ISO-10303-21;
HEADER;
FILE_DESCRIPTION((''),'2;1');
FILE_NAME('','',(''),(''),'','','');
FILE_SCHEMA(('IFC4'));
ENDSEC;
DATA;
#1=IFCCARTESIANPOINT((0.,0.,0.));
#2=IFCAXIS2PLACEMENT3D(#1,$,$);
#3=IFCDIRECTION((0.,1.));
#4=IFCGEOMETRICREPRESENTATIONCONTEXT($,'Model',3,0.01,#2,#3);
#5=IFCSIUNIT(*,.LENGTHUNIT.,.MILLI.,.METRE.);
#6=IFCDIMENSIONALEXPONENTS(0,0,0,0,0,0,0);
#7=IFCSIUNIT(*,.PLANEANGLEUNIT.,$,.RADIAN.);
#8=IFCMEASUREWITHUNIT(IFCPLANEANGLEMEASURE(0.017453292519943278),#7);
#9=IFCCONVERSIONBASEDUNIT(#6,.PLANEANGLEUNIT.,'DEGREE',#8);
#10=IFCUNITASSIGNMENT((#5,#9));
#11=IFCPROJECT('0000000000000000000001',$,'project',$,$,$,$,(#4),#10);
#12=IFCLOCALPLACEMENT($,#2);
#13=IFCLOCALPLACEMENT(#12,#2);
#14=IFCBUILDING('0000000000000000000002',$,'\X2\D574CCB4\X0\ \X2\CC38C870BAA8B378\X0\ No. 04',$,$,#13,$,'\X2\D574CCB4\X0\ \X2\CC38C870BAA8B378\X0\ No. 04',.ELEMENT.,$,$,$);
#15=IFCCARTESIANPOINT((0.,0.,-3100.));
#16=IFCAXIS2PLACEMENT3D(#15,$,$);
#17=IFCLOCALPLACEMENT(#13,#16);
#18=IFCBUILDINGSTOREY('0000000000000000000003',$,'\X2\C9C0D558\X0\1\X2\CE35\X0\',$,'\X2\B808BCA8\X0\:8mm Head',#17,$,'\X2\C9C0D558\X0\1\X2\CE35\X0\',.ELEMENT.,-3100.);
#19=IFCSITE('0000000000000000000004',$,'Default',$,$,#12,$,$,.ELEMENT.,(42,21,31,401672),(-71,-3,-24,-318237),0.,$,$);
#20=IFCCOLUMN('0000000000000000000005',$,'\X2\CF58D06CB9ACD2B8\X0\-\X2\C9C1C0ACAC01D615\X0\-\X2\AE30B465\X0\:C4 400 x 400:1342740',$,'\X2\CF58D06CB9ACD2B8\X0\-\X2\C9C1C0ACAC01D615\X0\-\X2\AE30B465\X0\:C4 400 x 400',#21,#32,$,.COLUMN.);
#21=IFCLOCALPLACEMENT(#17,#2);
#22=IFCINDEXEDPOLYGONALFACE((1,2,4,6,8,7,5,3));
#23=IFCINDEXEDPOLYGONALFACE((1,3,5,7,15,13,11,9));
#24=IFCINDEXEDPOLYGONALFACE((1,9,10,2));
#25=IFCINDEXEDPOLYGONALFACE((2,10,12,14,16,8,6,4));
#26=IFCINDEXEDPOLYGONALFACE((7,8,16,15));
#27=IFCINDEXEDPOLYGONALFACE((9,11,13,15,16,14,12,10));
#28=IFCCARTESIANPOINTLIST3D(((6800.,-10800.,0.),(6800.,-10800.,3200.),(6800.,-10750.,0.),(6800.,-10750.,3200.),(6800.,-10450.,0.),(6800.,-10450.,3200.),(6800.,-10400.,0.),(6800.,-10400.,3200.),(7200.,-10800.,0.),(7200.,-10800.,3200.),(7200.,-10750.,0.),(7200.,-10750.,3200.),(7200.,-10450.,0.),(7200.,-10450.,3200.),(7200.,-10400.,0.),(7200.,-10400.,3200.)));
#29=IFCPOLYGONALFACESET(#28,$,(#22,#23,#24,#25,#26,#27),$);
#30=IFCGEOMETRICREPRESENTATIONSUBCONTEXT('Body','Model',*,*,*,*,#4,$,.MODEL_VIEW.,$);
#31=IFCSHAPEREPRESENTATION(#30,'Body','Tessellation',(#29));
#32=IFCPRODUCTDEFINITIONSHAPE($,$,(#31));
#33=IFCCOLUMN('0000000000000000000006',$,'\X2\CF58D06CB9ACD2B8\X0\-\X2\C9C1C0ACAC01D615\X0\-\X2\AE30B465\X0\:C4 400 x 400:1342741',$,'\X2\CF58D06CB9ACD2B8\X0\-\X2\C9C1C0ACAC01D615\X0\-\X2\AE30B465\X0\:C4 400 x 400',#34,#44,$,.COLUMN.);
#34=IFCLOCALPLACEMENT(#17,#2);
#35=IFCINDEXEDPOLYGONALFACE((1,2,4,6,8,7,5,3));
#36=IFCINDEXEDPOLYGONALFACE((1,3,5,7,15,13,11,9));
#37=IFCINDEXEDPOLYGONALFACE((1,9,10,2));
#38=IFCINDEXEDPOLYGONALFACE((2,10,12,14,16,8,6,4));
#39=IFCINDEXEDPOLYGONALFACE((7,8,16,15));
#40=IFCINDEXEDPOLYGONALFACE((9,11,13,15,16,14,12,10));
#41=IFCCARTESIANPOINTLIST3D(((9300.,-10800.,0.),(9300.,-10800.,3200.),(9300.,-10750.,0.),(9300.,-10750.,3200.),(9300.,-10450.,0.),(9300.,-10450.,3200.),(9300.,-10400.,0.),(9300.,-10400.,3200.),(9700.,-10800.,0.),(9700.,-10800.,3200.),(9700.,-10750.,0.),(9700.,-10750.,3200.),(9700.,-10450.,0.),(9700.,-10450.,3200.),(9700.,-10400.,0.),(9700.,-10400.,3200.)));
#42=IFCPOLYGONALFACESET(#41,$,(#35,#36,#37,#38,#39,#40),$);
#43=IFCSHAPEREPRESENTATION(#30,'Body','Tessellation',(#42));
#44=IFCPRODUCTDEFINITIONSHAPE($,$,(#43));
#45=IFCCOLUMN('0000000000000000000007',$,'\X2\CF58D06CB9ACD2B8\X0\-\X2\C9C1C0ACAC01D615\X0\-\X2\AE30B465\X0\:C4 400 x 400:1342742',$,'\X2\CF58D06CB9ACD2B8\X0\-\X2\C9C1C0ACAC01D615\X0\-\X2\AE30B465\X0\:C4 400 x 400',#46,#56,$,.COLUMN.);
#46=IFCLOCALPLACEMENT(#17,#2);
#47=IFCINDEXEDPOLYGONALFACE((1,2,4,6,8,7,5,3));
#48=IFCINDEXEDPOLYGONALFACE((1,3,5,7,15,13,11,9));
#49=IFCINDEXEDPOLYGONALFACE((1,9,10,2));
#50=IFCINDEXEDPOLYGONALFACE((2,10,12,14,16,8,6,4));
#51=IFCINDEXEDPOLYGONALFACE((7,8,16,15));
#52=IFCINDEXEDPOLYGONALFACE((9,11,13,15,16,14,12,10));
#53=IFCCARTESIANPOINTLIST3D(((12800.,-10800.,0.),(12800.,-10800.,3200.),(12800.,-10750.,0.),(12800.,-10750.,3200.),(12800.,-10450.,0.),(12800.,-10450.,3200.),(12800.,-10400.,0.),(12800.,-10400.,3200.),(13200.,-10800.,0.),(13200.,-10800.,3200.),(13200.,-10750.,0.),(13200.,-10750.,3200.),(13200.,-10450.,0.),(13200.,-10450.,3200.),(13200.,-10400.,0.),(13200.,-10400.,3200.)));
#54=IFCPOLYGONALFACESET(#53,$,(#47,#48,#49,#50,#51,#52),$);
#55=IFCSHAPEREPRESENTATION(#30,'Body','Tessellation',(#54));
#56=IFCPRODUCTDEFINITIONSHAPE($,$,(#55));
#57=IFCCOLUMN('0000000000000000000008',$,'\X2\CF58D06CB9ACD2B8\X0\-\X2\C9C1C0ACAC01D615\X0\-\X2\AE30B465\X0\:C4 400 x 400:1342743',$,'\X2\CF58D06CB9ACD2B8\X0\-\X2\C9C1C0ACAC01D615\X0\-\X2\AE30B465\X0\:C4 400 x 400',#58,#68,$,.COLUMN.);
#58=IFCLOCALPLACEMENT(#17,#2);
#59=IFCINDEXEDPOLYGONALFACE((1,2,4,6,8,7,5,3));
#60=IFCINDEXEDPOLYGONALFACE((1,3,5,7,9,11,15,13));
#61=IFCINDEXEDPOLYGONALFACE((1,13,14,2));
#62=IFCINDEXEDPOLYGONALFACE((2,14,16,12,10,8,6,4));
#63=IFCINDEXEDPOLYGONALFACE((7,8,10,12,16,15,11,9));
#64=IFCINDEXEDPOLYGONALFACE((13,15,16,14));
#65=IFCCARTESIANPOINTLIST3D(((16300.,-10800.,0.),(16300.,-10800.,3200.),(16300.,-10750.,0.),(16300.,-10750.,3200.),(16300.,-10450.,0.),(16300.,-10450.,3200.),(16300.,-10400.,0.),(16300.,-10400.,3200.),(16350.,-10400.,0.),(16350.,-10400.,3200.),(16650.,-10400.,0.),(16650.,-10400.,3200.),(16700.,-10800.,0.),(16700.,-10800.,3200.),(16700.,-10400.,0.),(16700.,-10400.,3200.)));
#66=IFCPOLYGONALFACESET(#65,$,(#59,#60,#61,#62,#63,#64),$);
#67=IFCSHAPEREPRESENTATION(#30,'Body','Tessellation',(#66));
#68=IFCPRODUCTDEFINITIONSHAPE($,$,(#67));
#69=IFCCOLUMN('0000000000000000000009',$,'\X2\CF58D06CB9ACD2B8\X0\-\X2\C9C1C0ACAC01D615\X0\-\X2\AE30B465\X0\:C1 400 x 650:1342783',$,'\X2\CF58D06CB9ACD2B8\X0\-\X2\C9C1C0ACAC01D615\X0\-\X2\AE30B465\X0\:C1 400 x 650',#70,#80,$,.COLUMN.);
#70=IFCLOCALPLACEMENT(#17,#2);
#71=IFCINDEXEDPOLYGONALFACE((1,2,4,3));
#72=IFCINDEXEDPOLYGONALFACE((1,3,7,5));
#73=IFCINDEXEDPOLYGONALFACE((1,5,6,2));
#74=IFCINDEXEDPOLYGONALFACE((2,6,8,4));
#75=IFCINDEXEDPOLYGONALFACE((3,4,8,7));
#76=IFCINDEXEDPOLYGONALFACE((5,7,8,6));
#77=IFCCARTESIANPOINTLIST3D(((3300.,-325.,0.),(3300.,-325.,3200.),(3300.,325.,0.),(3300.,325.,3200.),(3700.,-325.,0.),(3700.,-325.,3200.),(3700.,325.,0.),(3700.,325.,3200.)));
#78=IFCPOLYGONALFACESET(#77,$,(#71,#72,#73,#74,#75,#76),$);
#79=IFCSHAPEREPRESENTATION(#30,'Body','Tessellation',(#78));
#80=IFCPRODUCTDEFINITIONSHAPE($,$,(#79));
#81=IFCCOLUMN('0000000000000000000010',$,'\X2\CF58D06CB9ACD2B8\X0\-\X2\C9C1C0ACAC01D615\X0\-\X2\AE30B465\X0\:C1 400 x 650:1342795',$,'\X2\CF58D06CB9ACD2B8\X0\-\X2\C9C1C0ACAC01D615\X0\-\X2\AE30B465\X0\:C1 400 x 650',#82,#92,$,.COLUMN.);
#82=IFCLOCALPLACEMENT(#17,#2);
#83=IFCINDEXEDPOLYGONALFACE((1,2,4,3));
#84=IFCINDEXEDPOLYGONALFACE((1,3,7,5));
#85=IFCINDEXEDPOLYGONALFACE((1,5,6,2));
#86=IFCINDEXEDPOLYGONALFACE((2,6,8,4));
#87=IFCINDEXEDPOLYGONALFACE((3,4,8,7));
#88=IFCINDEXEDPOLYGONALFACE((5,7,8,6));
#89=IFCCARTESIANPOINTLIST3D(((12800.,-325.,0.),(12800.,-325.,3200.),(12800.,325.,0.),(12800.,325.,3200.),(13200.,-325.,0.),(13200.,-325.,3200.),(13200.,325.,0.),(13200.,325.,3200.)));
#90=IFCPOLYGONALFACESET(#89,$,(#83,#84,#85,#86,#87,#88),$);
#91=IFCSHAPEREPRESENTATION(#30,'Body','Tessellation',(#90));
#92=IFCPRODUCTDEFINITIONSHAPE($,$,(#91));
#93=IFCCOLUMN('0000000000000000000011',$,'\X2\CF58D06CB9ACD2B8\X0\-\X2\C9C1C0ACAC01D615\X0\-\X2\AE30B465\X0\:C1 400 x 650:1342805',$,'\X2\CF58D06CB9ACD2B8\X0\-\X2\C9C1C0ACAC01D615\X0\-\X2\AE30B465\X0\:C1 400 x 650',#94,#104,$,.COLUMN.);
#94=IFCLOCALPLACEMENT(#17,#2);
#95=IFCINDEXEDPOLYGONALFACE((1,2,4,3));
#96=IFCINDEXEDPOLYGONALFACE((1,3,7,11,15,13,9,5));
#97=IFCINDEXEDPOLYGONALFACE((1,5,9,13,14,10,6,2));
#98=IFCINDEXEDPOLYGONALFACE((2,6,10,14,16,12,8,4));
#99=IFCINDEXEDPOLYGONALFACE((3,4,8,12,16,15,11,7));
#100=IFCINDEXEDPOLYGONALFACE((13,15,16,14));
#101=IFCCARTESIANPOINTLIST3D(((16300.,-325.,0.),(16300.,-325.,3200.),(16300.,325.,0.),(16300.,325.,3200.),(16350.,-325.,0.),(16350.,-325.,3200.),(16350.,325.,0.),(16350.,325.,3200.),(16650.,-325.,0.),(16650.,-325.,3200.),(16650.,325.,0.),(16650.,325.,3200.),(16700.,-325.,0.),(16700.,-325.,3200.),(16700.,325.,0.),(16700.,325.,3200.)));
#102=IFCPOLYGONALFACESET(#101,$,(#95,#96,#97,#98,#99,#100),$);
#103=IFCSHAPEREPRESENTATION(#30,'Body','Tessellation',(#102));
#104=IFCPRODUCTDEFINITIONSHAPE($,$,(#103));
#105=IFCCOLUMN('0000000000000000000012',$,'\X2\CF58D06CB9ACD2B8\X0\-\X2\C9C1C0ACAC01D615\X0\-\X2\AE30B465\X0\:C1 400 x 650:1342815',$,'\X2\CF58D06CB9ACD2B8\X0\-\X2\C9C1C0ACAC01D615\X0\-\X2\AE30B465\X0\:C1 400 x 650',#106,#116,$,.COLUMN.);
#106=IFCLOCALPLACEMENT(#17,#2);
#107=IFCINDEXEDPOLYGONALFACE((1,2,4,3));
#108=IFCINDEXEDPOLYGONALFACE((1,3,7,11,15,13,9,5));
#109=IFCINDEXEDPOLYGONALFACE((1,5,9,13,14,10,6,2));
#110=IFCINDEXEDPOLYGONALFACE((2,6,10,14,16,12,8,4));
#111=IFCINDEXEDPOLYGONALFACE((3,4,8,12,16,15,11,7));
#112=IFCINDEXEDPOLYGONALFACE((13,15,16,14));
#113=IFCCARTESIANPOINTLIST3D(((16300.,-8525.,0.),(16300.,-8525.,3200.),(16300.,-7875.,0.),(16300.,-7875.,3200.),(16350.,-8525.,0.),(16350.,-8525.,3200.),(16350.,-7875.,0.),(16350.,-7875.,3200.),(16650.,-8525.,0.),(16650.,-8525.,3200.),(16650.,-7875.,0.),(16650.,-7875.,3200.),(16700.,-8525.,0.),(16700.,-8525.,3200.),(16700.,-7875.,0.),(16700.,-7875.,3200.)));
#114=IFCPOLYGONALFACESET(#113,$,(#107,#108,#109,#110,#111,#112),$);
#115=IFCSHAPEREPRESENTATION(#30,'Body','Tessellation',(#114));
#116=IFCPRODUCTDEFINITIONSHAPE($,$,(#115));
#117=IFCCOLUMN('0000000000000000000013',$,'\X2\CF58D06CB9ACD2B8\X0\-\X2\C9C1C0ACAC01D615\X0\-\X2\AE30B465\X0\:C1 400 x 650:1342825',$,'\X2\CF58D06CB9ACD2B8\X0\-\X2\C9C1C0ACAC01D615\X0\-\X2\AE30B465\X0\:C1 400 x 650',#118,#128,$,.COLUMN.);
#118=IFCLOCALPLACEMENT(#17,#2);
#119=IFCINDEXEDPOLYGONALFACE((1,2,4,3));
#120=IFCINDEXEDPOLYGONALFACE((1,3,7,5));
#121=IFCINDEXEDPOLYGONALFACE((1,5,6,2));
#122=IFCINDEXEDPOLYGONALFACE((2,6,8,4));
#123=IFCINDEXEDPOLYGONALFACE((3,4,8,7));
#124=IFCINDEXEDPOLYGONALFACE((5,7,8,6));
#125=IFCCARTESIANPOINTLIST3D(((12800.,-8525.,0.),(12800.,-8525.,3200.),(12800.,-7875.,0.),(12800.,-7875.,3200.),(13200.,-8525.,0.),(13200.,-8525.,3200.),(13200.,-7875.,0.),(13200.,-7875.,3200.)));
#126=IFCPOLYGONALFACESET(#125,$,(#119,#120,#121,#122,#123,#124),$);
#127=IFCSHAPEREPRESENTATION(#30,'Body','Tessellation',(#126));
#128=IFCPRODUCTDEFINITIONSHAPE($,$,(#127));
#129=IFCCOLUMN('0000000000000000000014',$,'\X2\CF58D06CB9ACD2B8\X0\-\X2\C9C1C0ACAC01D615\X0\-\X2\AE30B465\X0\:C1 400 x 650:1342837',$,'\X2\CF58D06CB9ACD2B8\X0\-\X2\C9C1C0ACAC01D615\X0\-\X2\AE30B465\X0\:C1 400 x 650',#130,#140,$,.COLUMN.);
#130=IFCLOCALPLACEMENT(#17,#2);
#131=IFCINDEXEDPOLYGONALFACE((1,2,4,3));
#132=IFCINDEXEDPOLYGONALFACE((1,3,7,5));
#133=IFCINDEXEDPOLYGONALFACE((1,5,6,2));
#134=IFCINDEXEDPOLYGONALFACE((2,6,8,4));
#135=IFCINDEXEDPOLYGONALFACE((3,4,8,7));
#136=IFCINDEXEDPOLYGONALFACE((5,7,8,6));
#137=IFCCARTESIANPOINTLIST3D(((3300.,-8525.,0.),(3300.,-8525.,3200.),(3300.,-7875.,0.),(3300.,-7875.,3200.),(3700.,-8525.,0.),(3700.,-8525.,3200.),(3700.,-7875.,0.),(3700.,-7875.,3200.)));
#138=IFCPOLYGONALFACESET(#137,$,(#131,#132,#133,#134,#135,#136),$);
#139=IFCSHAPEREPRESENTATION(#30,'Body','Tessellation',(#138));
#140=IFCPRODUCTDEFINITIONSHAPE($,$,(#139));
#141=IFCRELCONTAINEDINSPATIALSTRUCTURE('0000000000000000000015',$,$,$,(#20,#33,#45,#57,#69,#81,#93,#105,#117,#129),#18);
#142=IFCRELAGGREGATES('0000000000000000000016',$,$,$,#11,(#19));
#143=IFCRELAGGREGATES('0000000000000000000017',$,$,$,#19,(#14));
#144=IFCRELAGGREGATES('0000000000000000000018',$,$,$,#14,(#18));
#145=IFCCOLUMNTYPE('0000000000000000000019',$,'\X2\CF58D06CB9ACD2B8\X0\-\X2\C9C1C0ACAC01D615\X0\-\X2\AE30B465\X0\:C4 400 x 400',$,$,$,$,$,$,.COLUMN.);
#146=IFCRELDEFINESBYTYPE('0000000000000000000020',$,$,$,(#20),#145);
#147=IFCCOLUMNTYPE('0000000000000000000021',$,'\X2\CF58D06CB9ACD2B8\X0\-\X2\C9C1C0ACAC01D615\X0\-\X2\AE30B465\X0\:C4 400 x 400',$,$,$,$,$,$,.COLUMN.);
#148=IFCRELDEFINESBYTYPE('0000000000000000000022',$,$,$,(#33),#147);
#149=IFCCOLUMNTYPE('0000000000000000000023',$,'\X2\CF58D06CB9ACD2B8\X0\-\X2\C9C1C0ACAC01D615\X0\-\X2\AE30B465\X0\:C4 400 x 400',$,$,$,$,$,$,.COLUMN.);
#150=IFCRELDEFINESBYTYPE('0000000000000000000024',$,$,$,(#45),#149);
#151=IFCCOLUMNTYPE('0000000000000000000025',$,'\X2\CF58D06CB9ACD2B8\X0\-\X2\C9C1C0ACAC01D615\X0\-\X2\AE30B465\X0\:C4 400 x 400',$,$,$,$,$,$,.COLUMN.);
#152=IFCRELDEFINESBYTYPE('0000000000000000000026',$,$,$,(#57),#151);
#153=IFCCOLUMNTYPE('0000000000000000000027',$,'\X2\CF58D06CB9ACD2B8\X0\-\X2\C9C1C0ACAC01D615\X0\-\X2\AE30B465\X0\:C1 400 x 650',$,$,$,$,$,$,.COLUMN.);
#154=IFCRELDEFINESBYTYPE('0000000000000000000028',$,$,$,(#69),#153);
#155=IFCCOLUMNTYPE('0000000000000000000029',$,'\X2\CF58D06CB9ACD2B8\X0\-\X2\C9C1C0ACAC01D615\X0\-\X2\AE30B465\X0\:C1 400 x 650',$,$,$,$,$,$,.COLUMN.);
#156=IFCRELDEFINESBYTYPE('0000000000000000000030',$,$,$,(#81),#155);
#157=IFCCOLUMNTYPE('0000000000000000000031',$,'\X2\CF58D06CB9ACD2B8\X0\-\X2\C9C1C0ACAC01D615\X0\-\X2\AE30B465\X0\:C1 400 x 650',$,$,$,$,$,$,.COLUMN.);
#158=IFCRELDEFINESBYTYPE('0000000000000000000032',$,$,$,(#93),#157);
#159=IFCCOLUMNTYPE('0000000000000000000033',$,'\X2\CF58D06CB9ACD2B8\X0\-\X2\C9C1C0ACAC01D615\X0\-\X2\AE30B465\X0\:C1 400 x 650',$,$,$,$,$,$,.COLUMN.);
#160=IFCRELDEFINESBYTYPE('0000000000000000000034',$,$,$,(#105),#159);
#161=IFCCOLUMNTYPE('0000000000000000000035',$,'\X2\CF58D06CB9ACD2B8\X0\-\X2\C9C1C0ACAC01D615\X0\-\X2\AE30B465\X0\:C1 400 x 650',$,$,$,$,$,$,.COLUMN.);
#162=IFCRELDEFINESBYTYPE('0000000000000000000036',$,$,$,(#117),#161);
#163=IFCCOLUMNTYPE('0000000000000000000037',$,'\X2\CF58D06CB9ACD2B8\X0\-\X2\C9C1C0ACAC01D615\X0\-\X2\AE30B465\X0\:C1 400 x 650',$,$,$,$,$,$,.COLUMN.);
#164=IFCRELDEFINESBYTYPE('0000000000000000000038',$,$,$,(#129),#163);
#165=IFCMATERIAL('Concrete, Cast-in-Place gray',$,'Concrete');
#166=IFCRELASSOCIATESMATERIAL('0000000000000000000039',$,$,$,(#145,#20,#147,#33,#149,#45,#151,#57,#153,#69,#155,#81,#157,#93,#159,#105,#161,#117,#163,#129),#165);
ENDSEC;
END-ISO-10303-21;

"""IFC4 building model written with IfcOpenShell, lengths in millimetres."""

from ifc_helpers import new_model, entity, si_unit, converted_unit, direction, frame, origin, place, context, subcontext, project, spatial, indexed_curve, outline, extrude, source, transform, mapped, material, type_object, type_shapes, element, save


model = new_model("IFC4")

# Units and contexts
model_context = context("Model", 3, precision=0.01, world=origin(), true_north=direction((0.0, 1.0)))
body_context = subcontext(model_context, "Body", "Model", "MODEL_VIEW")
ifc_project = project(units=[si_unit("LENGTHUNIT", "METRE", prefix="MILLI"), converted_unit("PLANEANGLEUNIT", "DEGREE", entity("IfcPlaneAngleMeasure", 0.017453292519943278), si_unit("PLANEANGLEUNIT", "RADIAN"), dimensions=[0, 0, 0, 0, 0, 0, 0])], contexts=[model_context])

# Site, building, storey
site_placement = place(None, origin())
site = spatial("IfcSite", under=ifc_project, at=site_placement, Name="Default", CompositionType="ELEMENT", RefLatitude=(42, 21, 31, 401672), RefLongitude=(-71, -3, -24, -318237), RefElevation=0.0)
building_placement = place(site_placement, origin())
building = spatial("IfcBuilding", under=site, at=building_placement, Name="해체 참조모델 No. 04", LongName="해체 참조모델 No. 04", CompositionType="ELEMENT")
storey_placement = place(building_placement, frame((0.0, 0.0, -3100.0)))
storey = spatial("IfcBuildingStorey", under=building, at=storey_placement, Name="지하1층", ObjectType="레벨:8mm Head", LongName="지하1층", CompositionType="ELEMENT", Elevation=-3100.0)

# Columns
ifc_material = material(Name="Concrete, Cast-in-Place gray", Category="Concrete")
column_type_1 = type_object("IfcColumnType", Name="콘크리트-직사각형-기둥:C4 400 x 400", PredefinedType="COLUMN", material=ifc_material)
shared_shape_1 = source(origin(), body_context, "Body", "SweptSolid", [
    extrude(outline(indexed_curve([(-200.0, -200.0), (200.0, -200.0), (200.0, -150.0), (200.0, 150.0), (200.0, 200.0), (-200.0, 200.0), (-200.0, 150.0), (-200.0, -150.0), (-200.0, -200.0)], self_intersect=False)), frame((7000.0, -10600.0, -3100.0), z_axis=(0.0, 0.0, 1.0), x_axis=(-1.0, 0.0, 0.0)), (0.0, 0.0, 1.0), 3200.0),
])
type_shapes(column_type_1, [shared_shape_1])
column_1_placement = place(storey_placement, frame((0.0, 0.0, 3100.0)))
element("IfcColumn", 1, at=column_1_placement, inside=storey, type_object=column_type_1, material=ifc_material, Name="콘크리트-직사각형-기둥:C4 400 x 400:1342740", ObjectType="콘크리트-직사각형-기둥:C4 400 x 400", PredefinedType="COLUMN", context=body_context, shape_type="MappedRepresentation", body=[
    mapped(shared_shape_1, transform((0.0, 0.0, 0.0), scale=1.0)),
])
column_type_2 = type_object("IfcColumnType", Name="콘크리트-직사각형-기둥:C4 400 x 400", PredefinedType="COLUMN", material=ifc_material)
shared_shape_2 = source(origin(), body_context, "Body", "SweptSolid", [
    extrude(outline(indexed_curve([(-200.0, -200.0), (200.0, -200.0), (200.0, -150.0), (200.0, 150.0), (200.0, 200.0), (-200.0, 200.0), (-200.0, 150.0), (-200.0, -150.0), (-200.0, -200.0)], self_intersect=False)), frame((9500.0, -10600.0, -3100.0), z_axis=(0.0, 0.0, 1.0), x_axis=(-1.0, 0.0, 0.0)), (0.0, 0.0, 1.0), 3200.0),
])
type_shapes(column_type_2, [shared_shape_2])
column_2_placement = place(storey_placement, frame((0.0, 0.0, 3100.0)))
element("IfcColumn", 2, at=column_2_placement, inside=storey, type_object=column_type_2, material=ifc_material, Name="콘크리트-직사각형-기둥:C4 400 x 400:1342741", ObjectType="콘크리트-직사각형-기둥:C4 400 x 400", PredefinedType="COLUMN", context=body_context, shape_type="MappedRepresentation", body=[
    mapped(shared_shape_2, transform((0.0, 0.0, 0.0), scale=1.0)),
])
column_type_3 = type_object("IfcColumnType", Name="콘크리트-직사각형-기둥:C4 400 x 400", PredefinedType="COLUMN", material=ifc_material)
shared_shape_3 = source(origin(), body_context, "Body", "SweptSolid", [
    extrude(outline(indexed_curve([(-200.0, -200.0), (200.0, -200.0), (200.0, -150.0), (200.0, 150.0), (200.0, 200.0), (-200.0, 200.0), (-200.0, 150.0), (-200.0, -150.0), (-200.0, -200.0)], self_intersect=False)), frame((13000.0, -10600.0, -3100.0), z_axis=(0.0, 0.0, 1.0), x_axis=(-1.0, 0.0, 0.0)), (0.0, 0.0, 1.0), 3200.0),
])
type_shapes(column_type_3, [shared_shape_3])
column_3_placement = place(storey_placement, frame((0.0, 0.0, 3100.0)))
element("IfcColumn", 3, at=column_3_placement, inside=storey, type_object=column_type_3, material=ifc_material, Name="콘크리트-직사각형-기둥:C4 400 x 400:1342742", ObjectType="콘크리트-직사각형-기둥:C4 400 x 400", PredefinedType="COLUMN", context=body_context, shape_type="MappedRepresentation", body=[
    mapped(shared_shape_3, transform((0.0, 0.0, 0.0), scale=1.0)),
])
column_type_4 = type_object("IfcColumnType", Name="콘크리트-직사각형-기둥:C4 400 x 400", PredefinedType="COLUMN", material=ifc_material)
shared_shape_4 = source(origin(), body_context, "Body", "SweptSolid", [
    extrude(outline(indexed_curve([(-250.0, -150.0), (-200.0, -150.0), (100.0, -150.0), (150.0, -150.0), (150.0, -100.0), (150.0, 200.0), (150.0, 250.0), (-250.0, 250.0), (-250.0, -150.0)], self_intersect=False)), frame((16450.0, -10550.0, -3100.0), z_axis=(0.0, 0.0, 1.0), x_axis=(-1.0, 0.0, 0.0)), (0.0, 0.0, 1.0), 3200.0),
])
type_shapes(column_type_4, [shared_shape_4])
column_4_placement = place(storey_placement, frame((0.0, 0.0, 3100.0)))
element("IfcColumn", 4, at=column_4_placement, inside=storey, type_object=column_type_4, material=ifc_material, Name="콘크리트-직사각형-기둥:C4 400 x 400:1342743", ObjectType="콘크리트-직사각형-기둥:C4 400 x 400", PredefinedType="COLUMN", context=body_context, shape_type="MappedRepresentation", body=[
    mapped(shared_shape_4, transform((0.0, 0.0, 0.0), scale=1.0)),
])
column_type_5 = type_object("IfcColumnType", Name="콘크리트-직사각형-기둥:C1 400 x 650", PredefinedType="COLUMN", material=ifc_material)
shared_shape_5 = source(origin(), body_context, "Body", "SweptSolid", [
    extrude(outline(indexed_curve([(-200.0, -325.0), (200.0, -325.0), (200.0, 325.0), (-200.0, 325.0), (-200.0, -325.0)], self_intersect=False)), frame((3500.0, 0.0, -3100.0), z_axis=(0.0, 0.0, 1.0), x_axis=(-1.0, 0.0, 0.0)), (0.0, 0.0, 1.0), 3200.0),
])
type_shapes(column_type_5, [shared_shape_5])
column_5_placement = place(storey_placement, frame((0.0, 0.0, 3100.0)))
element("IfcColumn", 5, at=column_5_placement, inside=storey, type_object=column_type_5, material=ifc_material, Name="콘크리트-직사각형-기둥:C1 400 x 650:1342783", ObjectType="콘크리트-직사각형-기둥:C1 400 x 650", PredefinedType="COLUMN", context=body_context, shape_type="MappedRepresentation", body=[
    mapped(shared_shape_5, transform((0.0, 0.0, 0.0), scale=1.0)),
])
column_type_6 = type_object("IfcColumnType", Name="콘크리트-직사각형-기둥:C1 400 x 650", PredefinedType="COLUMN", material=ifc_material)
shared_shape_6 = source(origin(), body_context, "Body", "SweptSolid", [
    extrude(outline(indexed_curve([(-200.0, -325.0), (200.0, -325.0), (200.0, 325.0), (-200.0, 325.0), (-200.0, -325.0)], self_intersect=False)), frame((13000.0, 0.0, -3100.0), z_axis=(0.0, 0.0, 1.0), x_axis=(-1.0, 0.0, 0.0)), (0.0, 0.0, 1.0), 3200.0),
])
type_shapes(column_type_6, [shared_shape_6])
column_6_placement = place(storey_placement, frame((0.0, 0.0, 3100.0)))
element("IfcColumn", 6, at=column_6_placement, inside=storey, type_object=column_type_6, material=ifc_material, Name="콘크리트-직사각형-기둥:C1 400 x 650:1342795", ObjectType="콘크리트-직사각형-기둥:C1 400 x 650", PredefinedType="COLUMN", context=body_context, shape_type="MappedRepresentation", body=[
    mapped(shared_shape_6, transform((0.0, 0.0, 0.0), scale=1.0)),
])
column_type_7 = type_object("IfcColumnType", Name="콘크리트-직사각형-기둥:C1 400 x 650", PredefinedType="COLUMN", material=ifc_material)
shared_shape_7 = source(origin(), body_context, "Body", "SweptSolid", [
    extrude(outline(indexed_curve([(-200.0, -325.0), (-150.0, -325.0), (150.0, -325.0), (200.0, -325.0), (200.0, 325.0), (150.0, 325.0), (-150.0, 325.0), (-200.0, 325.0), (-200.0, -325.0)], self_intersect=False)), frame((16500.0, 0.0, -3100.0), z_axis=(0.0, 0.0, 1.0), x_axis=(-1.0, 0.0, 0.0)), (0.0, 0.0, 1.0), 3200.0),
])
type_shapes(column_type_7, [shared_shape_7])
column_7_placement = place(storey_placement, frame((0.0, 0.0, 3100.0)))
element("IfcColumn", 7, at=column_7_placement, inside=storey, type_object=column_type_7, material=ifc_material, Name="콘크리트-직사각형-기둥:C1 400 x 650:1342805", ObjectType="콘크리트-직사각형-기둥:C1 400 x 650", PredefinedType="COLUMN", context=body_context, shape_type="MappedRepresentation", body=[
    mapped(shared_shape_7, transform((0.0, 0.0, 0.0), scale=1.0)),
])
column_type_8 = type_object("IfcColumnType", Name="콘크리트-직사각형-기둥:C1 400 x 650", PredefinedType="COLUMN", material=ifc_material)
shared_shape_8 = source(origin(), body_context, "Body", "SweptSolid", [
    extrude(outline(indexed_curve([(-200.0, -325.0), (-150.0, -325.0), (150.0, -325.0), (200.0, -325.0), (200.0, 325.0), (150.0, 325.0), (-150.0, 325.0), (-200.0, 325.0), (-200.0, -325.0)], self_intersect=False)), frame((16500.0, -8200.0, -3100.0), z_axis=(0.0, 0.0, 1.0), x_axis=(-1.0, 0.0, 0.0)), (0.0, 0.0, 1.0), 3200.0),
])
type_shapes(column_type_8, [shared_shape_8])
column_8_placement = place(storey_placement, frame((0.0, 0.0, 3100.0)))
element("IfcColumn", 8, at=column_8_placement, inside=storey, type_object=column_type_8, material=ifc_material, Name="콘크리트-직사각형-기둥:C1 400 x 650:1342815", ObjectType="콘크리트-직사각형-기둥:C1 400 x 650", PredefinedType="COLUMN", context=body_context, shape_type="MappedRepresentation", body=[
    mapped(shared_shape_8, transform((0.0, 0.0, 0.0), scale=1.0)),
])
column_type_9 = type_object("IfcColumnType", Name="콘크리트-직사각형-기둥:C1 400 x 650", PredefinedType="COLUMN", material=ifc_material)
shared_shape_9 = source(origin(), body_context, "Body", "SweptSolid", [
    extrude(outline(indexed_curve([(-200.0, -325.0), (200.0, -325.0), (200.0, 325.0), (-200.0, 325.0), (-200.0, -325.0)], self_intersect=False)), frame((13000.0, -8200.0, -3100.0), z_axis=(0.0, 0.0, 1.0), x_axis=(-1.0, 0.0, 0.0)), (0.0, 0.0, 1.0), 3200.0),
])
type_shapes(column_type_9, [shared_shape_9])
column_9_placement = place(storey_placement, frame((0.0, 0.0, 3100.0)))
element("IfcColumn", 9, at=column_9_placement, inside=storey, type_object=column_type_9, material=ifc_material, Name="콘크리트-직사각형-기둥:C1 400 x 650:1342825", ObjectType="콘크리트-직사각형-기둥:C1 400 x 650", PredefinedType="COLUMN", context=body_context, shape_type="MappedRepresentation", body=[
    mapped(shared_shape_9, transform((0.0, 0.0, 0.0), scale=1.0)),
])
column_type_10 = type_object("IfcColumnType", Name="콘크리트-직사각형-기둥:C1 400 x 650", PredefinedType="COLUMN", material=ifc_material)
shared_shape_10 = source(origin(), body_context, "Body", "SweptSolid", [
    extrude(outline(indexed_curve([(-200.0, -325.0), (200.0, -325.0), (200.0, 325.0), (-200.0, 325.0), (-200.0, -325.0)], self_intersect=False)), frame((3500.0, -8200.0, -3100.0), z_axis=(0.0, 0.0, 1.0), x_axis=(-1.0, 0.0, 0.0)), (0.0, 0.0, 1.0), 3200.0),
])
type_shapes(column_type_10, [shared_shape_10])
column_10_placement = place(storey_placement, frame((0.0, 0.0, 3100.0)))
element("IfcColumn", 10, at=column_10_placement, inside=storey, type_object=column_type_10, material=ifc_material, Name="콘크리트-직사각형-기둥:C1 400 x 650:1342837", ObjectType="콘크리트-직사각형-기둥:C1 400 x 650", PredefinedType="COLUMN", context=body_context, shape_type="MappedRepresentation", body=[
    mapped(shared_shape_10, transform((0.0, 0.0, 0.0), scale=1.0)),
])

save(model, "model.ifc")
